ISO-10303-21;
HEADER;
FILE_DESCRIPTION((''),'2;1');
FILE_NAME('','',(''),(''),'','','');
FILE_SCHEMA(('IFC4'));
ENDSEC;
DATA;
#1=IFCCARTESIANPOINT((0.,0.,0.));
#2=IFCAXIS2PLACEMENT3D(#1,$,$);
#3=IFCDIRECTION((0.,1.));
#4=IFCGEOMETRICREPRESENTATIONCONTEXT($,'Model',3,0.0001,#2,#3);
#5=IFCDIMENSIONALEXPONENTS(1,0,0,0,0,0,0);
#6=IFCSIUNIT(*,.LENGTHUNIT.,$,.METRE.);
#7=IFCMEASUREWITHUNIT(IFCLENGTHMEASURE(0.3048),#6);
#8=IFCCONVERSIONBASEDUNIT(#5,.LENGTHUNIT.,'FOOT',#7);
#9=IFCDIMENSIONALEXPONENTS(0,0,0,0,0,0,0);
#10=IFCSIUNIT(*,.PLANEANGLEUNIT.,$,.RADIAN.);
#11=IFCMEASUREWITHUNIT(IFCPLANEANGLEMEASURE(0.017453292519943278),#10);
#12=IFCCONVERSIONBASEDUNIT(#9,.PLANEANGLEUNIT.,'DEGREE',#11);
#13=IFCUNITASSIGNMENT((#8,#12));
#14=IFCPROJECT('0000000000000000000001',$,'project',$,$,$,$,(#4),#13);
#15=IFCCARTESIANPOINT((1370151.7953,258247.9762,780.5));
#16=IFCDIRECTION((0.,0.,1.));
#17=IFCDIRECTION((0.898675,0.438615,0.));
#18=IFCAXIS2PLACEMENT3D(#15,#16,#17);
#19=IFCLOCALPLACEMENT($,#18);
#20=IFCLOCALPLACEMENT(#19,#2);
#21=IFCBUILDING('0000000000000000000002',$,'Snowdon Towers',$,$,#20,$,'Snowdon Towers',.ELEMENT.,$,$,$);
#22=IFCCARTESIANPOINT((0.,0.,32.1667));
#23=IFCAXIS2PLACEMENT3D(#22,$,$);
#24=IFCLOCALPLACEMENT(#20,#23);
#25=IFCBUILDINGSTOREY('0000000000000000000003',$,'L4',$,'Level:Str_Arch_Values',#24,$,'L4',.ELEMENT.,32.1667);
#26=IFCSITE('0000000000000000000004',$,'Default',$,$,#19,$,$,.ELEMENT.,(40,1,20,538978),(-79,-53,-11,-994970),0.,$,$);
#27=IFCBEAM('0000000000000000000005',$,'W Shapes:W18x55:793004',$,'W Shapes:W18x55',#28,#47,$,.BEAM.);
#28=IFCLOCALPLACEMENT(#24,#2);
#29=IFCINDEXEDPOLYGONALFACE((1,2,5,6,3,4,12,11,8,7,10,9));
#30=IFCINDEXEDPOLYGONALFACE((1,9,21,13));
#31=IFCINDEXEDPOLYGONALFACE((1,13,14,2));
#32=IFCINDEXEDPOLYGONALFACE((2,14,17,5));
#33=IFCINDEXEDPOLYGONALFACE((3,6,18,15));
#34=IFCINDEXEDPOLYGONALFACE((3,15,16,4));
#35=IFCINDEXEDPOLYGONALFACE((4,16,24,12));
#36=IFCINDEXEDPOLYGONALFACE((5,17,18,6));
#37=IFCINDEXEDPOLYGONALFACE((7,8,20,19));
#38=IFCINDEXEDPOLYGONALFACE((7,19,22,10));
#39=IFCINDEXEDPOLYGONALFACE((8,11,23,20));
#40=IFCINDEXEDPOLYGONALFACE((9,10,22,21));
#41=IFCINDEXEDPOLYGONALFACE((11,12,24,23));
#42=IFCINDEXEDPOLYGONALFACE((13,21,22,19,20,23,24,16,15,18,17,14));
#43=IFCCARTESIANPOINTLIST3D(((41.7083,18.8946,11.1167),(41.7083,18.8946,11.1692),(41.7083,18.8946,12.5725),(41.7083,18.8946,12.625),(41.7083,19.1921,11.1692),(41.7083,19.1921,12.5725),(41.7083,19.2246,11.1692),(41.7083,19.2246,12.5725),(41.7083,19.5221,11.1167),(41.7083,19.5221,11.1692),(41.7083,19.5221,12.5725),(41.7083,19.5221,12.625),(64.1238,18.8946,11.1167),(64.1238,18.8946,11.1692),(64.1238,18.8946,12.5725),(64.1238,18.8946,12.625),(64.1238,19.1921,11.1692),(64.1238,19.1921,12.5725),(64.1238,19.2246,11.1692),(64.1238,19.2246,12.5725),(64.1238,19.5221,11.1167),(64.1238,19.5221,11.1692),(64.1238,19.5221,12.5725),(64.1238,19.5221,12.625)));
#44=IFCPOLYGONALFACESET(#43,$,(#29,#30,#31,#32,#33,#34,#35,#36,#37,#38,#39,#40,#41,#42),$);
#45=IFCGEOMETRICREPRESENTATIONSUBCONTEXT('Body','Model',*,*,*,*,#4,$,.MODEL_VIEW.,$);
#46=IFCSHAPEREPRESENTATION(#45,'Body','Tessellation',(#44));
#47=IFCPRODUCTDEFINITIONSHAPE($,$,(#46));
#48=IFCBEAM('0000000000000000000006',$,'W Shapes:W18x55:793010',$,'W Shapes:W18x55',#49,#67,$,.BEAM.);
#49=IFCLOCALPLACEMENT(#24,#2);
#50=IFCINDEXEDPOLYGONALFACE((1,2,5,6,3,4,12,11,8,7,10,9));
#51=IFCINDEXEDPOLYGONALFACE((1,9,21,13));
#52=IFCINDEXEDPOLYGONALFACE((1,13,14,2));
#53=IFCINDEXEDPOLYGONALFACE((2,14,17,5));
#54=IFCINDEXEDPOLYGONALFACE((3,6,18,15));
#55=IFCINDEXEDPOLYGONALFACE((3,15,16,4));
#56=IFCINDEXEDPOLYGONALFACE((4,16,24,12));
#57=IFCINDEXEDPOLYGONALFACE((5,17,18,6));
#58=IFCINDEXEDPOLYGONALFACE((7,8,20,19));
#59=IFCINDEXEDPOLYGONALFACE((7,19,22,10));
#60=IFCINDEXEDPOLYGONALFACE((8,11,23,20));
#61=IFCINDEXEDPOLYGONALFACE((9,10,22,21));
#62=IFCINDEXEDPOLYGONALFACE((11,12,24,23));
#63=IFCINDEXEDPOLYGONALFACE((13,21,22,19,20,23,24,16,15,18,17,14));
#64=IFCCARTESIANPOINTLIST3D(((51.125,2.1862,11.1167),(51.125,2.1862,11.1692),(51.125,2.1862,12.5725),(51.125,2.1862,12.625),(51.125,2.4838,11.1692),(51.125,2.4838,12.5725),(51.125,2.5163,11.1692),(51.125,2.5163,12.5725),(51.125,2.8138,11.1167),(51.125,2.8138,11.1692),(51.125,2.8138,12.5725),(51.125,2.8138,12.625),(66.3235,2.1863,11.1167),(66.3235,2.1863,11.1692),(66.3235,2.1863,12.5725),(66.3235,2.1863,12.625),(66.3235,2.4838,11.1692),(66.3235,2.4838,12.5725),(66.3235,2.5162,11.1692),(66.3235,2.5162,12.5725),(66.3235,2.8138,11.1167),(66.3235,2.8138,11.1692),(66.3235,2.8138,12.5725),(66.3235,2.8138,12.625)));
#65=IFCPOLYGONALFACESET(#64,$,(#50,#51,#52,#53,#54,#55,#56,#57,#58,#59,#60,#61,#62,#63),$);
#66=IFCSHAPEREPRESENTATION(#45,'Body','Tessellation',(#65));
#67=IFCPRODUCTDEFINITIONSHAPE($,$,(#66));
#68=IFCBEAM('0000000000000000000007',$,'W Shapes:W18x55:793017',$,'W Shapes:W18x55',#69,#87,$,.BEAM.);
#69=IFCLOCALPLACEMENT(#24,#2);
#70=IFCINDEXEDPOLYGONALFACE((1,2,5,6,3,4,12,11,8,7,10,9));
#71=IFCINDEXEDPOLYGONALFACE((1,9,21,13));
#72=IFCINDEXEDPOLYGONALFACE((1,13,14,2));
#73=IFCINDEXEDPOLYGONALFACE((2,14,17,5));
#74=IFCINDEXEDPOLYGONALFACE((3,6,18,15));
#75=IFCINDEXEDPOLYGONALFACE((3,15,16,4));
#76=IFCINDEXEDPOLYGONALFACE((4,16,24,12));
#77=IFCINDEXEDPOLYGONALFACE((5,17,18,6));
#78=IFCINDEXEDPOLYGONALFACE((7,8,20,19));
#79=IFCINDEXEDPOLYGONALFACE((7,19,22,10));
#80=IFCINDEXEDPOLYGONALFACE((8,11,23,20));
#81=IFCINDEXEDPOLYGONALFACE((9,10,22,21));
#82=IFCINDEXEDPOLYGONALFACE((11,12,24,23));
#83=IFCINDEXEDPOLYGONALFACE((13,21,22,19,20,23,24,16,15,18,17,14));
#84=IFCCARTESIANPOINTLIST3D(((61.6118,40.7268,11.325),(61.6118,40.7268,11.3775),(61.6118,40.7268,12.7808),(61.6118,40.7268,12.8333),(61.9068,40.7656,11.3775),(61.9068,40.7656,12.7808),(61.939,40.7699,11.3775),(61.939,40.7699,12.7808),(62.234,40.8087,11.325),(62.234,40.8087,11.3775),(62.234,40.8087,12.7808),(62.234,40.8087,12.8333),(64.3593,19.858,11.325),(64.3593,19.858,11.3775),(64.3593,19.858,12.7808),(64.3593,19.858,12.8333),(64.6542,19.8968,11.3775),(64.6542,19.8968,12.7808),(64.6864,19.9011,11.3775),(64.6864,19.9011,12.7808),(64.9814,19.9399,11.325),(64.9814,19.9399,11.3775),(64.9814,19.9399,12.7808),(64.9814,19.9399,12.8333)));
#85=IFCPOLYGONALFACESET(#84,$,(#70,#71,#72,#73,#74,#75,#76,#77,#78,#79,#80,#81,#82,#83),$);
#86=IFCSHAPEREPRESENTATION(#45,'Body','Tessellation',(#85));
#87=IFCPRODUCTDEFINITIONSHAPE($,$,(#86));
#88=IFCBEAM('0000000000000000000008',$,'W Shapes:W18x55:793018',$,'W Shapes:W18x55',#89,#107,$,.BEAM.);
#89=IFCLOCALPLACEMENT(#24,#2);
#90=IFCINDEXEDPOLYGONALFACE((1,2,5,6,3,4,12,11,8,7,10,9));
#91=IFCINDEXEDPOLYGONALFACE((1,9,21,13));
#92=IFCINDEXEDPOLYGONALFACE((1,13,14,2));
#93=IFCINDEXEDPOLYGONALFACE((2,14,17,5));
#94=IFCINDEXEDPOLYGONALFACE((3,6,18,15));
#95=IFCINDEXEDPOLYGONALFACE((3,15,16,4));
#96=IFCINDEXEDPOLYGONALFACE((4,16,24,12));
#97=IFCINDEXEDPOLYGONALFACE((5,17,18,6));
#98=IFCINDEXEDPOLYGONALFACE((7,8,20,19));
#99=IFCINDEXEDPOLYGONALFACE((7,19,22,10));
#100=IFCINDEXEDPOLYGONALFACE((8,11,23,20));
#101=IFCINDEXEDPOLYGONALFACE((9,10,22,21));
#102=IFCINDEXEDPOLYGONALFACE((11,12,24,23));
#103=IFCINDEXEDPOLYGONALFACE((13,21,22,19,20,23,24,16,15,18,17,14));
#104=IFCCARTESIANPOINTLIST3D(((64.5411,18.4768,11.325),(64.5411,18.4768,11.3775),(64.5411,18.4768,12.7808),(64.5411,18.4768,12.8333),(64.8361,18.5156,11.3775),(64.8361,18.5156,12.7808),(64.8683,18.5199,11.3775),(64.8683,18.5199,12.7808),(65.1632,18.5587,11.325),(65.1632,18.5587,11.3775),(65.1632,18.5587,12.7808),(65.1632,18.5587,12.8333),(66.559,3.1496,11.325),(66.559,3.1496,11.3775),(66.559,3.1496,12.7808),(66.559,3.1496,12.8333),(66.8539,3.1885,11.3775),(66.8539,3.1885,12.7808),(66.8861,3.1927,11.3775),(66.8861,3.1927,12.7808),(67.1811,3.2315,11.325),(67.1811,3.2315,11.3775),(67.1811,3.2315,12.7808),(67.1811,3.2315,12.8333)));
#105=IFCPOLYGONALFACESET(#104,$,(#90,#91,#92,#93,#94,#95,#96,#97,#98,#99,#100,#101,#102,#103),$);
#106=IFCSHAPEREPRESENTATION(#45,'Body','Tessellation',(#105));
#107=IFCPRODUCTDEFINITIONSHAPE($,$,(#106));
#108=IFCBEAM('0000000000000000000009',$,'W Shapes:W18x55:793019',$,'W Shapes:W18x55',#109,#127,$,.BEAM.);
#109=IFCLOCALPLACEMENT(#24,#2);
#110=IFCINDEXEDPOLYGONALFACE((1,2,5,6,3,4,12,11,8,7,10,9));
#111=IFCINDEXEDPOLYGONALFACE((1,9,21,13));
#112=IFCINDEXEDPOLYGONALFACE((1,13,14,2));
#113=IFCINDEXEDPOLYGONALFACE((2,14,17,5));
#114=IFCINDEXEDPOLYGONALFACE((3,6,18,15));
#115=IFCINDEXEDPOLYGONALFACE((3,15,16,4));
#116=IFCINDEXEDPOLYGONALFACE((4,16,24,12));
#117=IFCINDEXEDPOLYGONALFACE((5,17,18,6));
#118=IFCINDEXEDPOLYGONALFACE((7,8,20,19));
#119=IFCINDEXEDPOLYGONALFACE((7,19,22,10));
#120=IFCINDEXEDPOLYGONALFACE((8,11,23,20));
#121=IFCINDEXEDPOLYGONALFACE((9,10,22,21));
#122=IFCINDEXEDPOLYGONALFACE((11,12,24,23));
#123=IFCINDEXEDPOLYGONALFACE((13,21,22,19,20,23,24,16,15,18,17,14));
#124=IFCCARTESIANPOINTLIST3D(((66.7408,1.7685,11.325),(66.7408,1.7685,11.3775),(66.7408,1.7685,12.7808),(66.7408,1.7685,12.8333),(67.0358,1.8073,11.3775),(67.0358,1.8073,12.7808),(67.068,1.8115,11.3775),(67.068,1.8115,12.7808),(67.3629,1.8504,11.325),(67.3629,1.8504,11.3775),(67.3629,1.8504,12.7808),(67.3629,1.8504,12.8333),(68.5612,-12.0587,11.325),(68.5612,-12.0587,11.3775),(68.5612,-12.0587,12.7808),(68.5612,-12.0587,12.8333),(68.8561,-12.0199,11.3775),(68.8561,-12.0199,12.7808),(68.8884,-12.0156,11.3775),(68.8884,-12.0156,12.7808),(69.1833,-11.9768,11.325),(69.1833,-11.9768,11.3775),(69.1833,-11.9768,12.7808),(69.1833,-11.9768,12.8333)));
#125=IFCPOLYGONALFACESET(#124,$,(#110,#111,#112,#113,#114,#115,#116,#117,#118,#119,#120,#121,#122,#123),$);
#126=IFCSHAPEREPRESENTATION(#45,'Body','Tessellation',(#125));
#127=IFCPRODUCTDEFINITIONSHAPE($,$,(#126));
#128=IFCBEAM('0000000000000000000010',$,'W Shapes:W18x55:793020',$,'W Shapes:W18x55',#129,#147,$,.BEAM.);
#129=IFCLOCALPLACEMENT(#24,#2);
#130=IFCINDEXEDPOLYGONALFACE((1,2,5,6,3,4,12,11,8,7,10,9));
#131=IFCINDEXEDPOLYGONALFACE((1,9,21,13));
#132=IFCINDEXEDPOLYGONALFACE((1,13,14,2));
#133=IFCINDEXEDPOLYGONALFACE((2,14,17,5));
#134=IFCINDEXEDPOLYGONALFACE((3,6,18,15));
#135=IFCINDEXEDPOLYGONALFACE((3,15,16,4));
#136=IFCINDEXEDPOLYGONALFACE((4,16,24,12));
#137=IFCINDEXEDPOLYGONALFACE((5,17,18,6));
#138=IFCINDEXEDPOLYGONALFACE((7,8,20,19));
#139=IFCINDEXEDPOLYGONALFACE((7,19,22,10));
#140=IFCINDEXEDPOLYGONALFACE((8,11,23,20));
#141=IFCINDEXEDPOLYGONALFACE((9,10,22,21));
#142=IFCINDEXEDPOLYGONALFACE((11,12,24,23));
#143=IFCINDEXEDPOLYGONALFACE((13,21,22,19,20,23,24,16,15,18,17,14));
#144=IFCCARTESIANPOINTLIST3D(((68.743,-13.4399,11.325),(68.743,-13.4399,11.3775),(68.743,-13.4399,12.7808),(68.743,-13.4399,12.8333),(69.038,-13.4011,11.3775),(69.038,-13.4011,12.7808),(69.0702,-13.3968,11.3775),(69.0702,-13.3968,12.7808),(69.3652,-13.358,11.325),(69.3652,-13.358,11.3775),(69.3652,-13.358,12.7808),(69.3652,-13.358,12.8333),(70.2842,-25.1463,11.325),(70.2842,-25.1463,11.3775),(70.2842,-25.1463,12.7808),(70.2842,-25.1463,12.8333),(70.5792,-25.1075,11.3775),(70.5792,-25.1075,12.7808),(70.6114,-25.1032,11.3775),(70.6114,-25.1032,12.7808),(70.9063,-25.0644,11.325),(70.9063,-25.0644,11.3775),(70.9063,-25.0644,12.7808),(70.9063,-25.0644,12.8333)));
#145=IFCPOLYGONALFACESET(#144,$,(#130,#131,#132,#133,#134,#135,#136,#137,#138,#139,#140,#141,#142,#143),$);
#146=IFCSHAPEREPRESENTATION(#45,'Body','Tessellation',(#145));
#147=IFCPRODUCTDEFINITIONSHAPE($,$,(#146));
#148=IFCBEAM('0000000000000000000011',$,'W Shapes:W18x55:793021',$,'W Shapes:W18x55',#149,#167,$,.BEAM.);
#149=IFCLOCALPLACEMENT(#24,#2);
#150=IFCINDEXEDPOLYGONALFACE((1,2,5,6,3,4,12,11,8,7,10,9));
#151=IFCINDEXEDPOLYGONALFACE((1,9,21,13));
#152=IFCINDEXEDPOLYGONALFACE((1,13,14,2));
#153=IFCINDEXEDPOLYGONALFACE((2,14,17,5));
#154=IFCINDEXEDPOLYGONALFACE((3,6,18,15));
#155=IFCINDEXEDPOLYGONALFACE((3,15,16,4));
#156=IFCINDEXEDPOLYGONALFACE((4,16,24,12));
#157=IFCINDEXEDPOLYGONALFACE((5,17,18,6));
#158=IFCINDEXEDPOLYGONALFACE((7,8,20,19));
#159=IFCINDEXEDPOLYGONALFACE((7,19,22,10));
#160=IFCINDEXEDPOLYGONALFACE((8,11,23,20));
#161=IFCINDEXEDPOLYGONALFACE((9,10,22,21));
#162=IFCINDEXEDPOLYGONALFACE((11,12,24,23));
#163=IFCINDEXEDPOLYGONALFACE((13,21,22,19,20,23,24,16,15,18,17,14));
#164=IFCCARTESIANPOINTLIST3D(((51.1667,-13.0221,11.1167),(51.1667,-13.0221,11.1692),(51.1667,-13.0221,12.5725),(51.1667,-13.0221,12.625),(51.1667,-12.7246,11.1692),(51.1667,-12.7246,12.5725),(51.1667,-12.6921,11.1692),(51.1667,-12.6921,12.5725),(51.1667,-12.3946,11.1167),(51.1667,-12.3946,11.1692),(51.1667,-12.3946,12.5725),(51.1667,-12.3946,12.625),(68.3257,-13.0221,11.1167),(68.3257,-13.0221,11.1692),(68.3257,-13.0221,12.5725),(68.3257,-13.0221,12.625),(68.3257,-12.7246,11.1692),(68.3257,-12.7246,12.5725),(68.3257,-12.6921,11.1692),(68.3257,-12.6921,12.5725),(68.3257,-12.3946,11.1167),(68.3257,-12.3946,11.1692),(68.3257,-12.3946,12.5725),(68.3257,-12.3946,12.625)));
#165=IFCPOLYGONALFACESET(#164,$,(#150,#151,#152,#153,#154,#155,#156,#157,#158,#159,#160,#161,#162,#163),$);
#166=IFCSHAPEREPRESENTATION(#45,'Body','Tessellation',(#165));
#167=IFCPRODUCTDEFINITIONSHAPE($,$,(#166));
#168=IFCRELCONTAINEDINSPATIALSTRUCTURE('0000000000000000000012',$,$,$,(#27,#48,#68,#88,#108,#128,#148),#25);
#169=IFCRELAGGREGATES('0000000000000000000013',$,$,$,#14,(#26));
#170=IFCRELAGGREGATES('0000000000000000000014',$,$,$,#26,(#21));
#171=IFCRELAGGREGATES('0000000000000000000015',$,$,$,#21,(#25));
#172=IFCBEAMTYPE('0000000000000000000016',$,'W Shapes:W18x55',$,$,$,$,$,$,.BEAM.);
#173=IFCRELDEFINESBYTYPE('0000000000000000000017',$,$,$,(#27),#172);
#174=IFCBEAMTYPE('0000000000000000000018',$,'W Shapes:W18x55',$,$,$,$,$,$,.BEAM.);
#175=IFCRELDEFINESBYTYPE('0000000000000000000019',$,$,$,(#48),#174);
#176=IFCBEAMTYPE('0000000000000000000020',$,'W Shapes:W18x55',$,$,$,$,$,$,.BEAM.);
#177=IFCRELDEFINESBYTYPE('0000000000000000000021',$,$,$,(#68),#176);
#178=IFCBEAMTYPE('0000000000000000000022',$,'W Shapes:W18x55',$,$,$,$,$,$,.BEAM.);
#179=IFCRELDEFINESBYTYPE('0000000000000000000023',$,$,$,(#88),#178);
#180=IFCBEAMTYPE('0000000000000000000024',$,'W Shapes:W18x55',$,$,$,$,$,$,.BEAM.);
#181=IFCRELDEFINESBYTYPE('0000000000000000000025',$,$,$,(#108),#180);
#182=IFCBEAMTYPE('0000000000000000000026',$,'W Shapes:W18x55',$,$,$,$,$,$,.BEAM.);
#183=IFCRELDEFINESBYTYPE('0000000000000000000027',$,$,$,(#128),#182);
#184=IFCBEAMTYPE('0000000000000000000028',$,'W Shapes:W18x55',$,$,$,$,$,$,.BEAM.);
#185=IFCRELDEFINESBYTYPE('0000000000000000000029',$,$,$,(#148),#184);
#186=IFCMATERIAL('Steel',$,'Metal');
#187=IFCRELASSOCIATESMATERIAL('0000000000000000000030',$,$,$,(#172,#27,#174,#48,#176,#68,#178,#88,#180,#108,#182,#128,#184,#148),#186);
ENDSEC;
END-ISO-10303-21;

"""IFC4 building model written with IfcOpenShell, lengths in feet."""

from ifc_helpers import new_model, entity, si_unit, converted_unit, direction, frame, origin, place, context, subcontext, project, spatial, indexed_curve, outline, extrude, source, transform, mapped, material, type_object, type_shapes, element, save


model = new_model("IFC4")

# Units and contexts
model_context = context("Model", 3, precision=0.0001, world=origin(), true_north=direction((0.0, 1.0)))
body_context = subcontext(model_context, "Body", "Model", "MODEL_VIEW")
ifc_project = project(units=[converted_unit("LENGTHUNIT", "FOOT", entity("IfcLengthMeasure", 0.3048), si_unit("LENGTHUNIT", "METRE"), dimensions=[1, 0, 0, 0, 0, 0, 0]), converted_unit("PLANEANGLEUNIT", "DEGREE", entity("IfcPlaneAngleMeasure", 0.017453292519943278), si_unit("PLANEANGLEUNIT", "RADIAN"), dimensions=[0, 0, 0, 0, 0, 0, 0])], contexts=[model_context])

# Site, building, storey
site_placement = place(None, frame((1370151.7953, 258247.9762, 780.5), z_axis=(0.0, 0.0, 1.0), x_axis=(0.898675, 0.438615, 0.0)))
site = spatial("IfcSite", under=ifc_project, at=site_placement, Name="Default", CompositionType="ELEMENT", RefLatitude=(40, 1, 20, 538978), RefLongitude=(-79, -53, -11, -994970), RefElevation=0.0)
building_placement = place(site_placement, origin())
building = spatial("IfcBuilding", under=site, at=building_placement, Name="Snowdon Towers", LongName="Snowdon Towers", CompositionType="ELEMENT")
storey_placement = place(building_placement, frame((0.0, 0.0, 32.1667)))
storey = spatial("IfcBuildingStorey", under=building, at=storey_placement, Name="L4", ObjectType="Level:Str_Arch_Values", LongName="L4", CompositionType="ELEMENT", Elevation=32.1667)

# Shared definitions
ifc_material = material(Name="Steel", Category="Metal")

# Beams
beam_type_1 = type_object("IfcBeamType", Name="W Shapes:W18x55", PredefinedType="BEAM", material=ifc_material)
shared_shape_1 = source(origin(), body_context, "Body", "SweptSolid", [
    extrude(outline(indexed_curve([(-0.3138, -0.7017), (-0.3138, -0.7542), (0.3138, -0.7542), (0.3138, -0.7017), (0.0162, -0.7017), (0.0162, 0.7017), (0.3138, 0.7017), (0.3138, 0.7542), (-0.3137, 0.7542), (-0.3137, 0.7017), (-0.0163, 0.7017), (-0.0163, -0.7017), (-0.3138, -0.7017)], self_intersect=False)), frame((-11.5915, 0.0, 0.0), z_axis=(-1.0, 0.0, 0.0), x_axis=(0.0, -1.0, 0.0)), (0.0, 0.0, -1.0), 22.4154),
])
type_shapes(beam_type_1, [shared_shape_1])
beam_1_placement = place(storey_placement, frame((53.2998, 19.2083, 11.8708)))
element("IfcBeam", 1, at=beam_1_placement, inside=storey, type_object=beam_type_1, material=ifc_material, Name="W Shapes:W18x55:793004", ObjectType="W Shapes:W18x55", PredefinedType="BEAM", context=body_context, shape_type="MappedRepresentation", body=[
    mapped(shared_shape_1, transform((0.0, 0.0, 0.0), scale=1.0)),
])
beam_type_2 = type_object("IfcBeamType", Name="W Shapes:W18x55", PredefinedType="BEAM", material=ifc_material)
shared_shape_2 = source(origin(), body_context, "Body", "SweptSolid", [
    extrude(outline(indexed_curve([(-0.3138, -0.7017), (-0.3138, -0.7542), (0.3138, -0.7542), (0.3138, -0.7017), (0.0162, -0.7017), (0.0162, 0.7017), (0.3138, 0.7017), (0.3138, 0.7542), (-0.3137, 0.7542), (-0.3137, 0.7017), (-0.0163, 0.7017), (-0.0163, -0.7017), (-0.3138, -0.7017)], self_intersect=False)), frame((-8.2122, 0.0, 0.0), z_axis=(-1.0, 0.0, 0.0), x_axis=(0.0, -1.0, 0.0)), (0.0, 0.0, -1.0), 15.1985),
])
type_shapes(beam_type_2, [shared_shape_2])
beam_2_placement = place(storey_placement, frame((59.3372, 2.5, 11.8708)))
element("IfcBeam", 2, at=beam_2_placement, inside=storey, type_object=beam_type_2, material=ifc_material, Name="W Shapes:W18x55:793010", ObjectType="W Shapes:W18x55", PredefinedType="BEAM", context=body_context, shape_type="MappedRepresentation", body=[
    mapped(shared_shape_2, transform((0.0, 0.0, 0.0), scale=1.0)),
])
beam_type_3 = type_object("IfcBeamType", Name="W Shapes:W18x55", PredefinedType="BEAM", material=ifc_material)
shared_shape_3 = source(origin(), body_context, "Body", "SweptSolid", [
    extrude(outline(indexed_curve([(-0.3138, -0.7017), (-0.3138, -0.7542), (0.3138, -0.7542), (0.3138, -0.7017), (0.0162, -0.7017), (0.0162, 0.7017), (0.3138, 0.7017), (0.3138, 0.7542), (-0.3137, 0.7542), (-0.3137, 0.7017), (-0.0163, 0.7017), (-0.0163, -0.7017), (-0.3138, -0.7017)], self_intersect=False)), frame((-10.5172, 0.0, 0.0), z_axis=(-1.0, 0.0, 0.0), x_axis=(0.0, -1.0, 0.0)), (0.0, 0.0, -1.0), 21.0489),
])
type_shapes(beam_type_3, [shared_shape_3])
beam_3_placement = place(storey_placement, frame((63.2957, 30.3405, 12.0792), z_axis=(0.0, 0.0, 1.0), x_axis=(0.130526, -0.991445, 0.0)))
element("IfcBeam", 3, at=beam_3_placement, inside=storey, type_object=beam_type_3, material=ifc_material, Name="W Shapes:W18x55:793017", ObjectType="W Shapes:W18x55", PredefinedType="BEAM", context=body_context, shape_type="MappedRepresentation", body=[
    mapped(shared_shape_3, transform((0.0, 0.0, 0.0), scale=1.0)),
])
beam_type_4 = type_object("IfcBeamType", Name="W Shapes:W18x55", PredefinedType="BEAM", material=ifc_material)
shared_shape_4 = source(origin(), body_context, "Body", "SweptSolid", [
    extrude(outline(indexed_curve([(-0.3138, -0.7017), (-0.3138, -0.7542), (0.3138, -0.7542), (0.3138, -0.7017), (0.0162, -0.7017), (0.0162, 0.7017), (0.3138, 0.7017), (0.3138, 0.7542), (-0.3137, 0.7542), (-0.3137, 0.7017), (-0.0163, 0.7017), (-0.0163, -0.7017), (-0.3138, -0.7017)], self_intersect=False)), frame((-7.8065, 0.0, 0.0), z_axis=(-1.0, 0.0, 0.0), x_axis=(0.0, -1.0, 0.0)), (0.0, 0.0, -1.0), 15.4594),
])
type_shapes(beam_type_4, [shared_shape_4])
beam_4_placement = place(storey_placement, frame((65.8711, 10.778, 12.0792), z_axis=(0.0, 0.0, 1.0), x_axis=(0.130526, -0.991445, 0.0)))
element("IfcBeam", 4, at=beam_4_placement, inside=storey, type_object=beam_type_4, material=ifc_material, Name="W Shapes:W18x55:793018", ObjectType="W Shapes:W18x55", PredefinedType="BEAM", context=body_context, shape_type="MappedRepresentation", body=[
    mapped(shared_shape_4, transform((0.0, 0.0, 0.0), scale=1.0)),
])
beam_type_5 = type_object("IfcBeamType", Name="W Shapes:W18x55", PredefinedType="BEAM", material=ifc_material)
shared_shape_5 = source(origin(), body_context, "Body", "SweptSolid", [
    extrude(outline(indexed_curve([(-0.3138, -0.7017), (-0.3138, -0.7542), (0.3138, -0.7542), (0.3138, -0.7017), (0.0162, -0.7017), (0.0162, 0.7017), (0.3138, 0.7017), (0.3138, 0.7542), (-0.3137, 0.7542), (-0.3137, 0.7017), (-0.0163, 0.7017), (-0.0163, -0.7017), (-0.3138, -0.7017)], self_intersect=False)), frame((-7.05, 0.0, 0.0), z_axis=(-1.0, 0.0, 0.0), x_axis=(0.0, -1.0, 0.0)), (0.0, 0.0, -1.0), 13.9465),
])
type_shapes(beam_type_5, [shared_shape_5])
beam_5_placement = place(storey_placement, frame((67.9721, -5.1803, 12.0792), z_axis=(0.0, 0.0, 1.0), x_axis=(0.130526, -0.991445, 0.0)))
element("IfcBeam", 5, at=beam_5_placement, inside=storey, type_object=beam_type_5, material=ifc_material, Name="W Shapes:W18x55:793019", ObjectType="W Shapes:W18x55", PredefinedType="BEAM", context=body_context, shape_type="MappedRepresentation", body=[
    mapped(shared_shape_5, transform((0.0, 0.0, 0.0), scale=1.0)),
])
beam_type_6 = type_object("IfcBeamType", Name="W Shapes:W18x55", PredefinedType="BEAM", material=ifc_material)
shared_shape_6 = source(origin(), body_context, "Body", "SweptSolid", [
    extrude(outline(indexed_curve([(-0.3138, -0.7017), (-0.3138, -0.7542), (0.3138, -0.7542), (0.3138, -0.7017), (0.0162, -0.7017), (0.0162, 0.7017), (0.3138, 0.7017), (0.3138, 0.7542), (-0.3137, 0.7542), (-0.3137, 0.7017), (-0.0163, 0.7017), (-0.0163, -0.7017), (-0.3138, -0.7017)], self_intersect=False)), frame((-5.9188, 0.0, 0.0), z_axis=(-1.0, 0.0, 0.0), x_axis=(0.0, -1.0, 0.0)), (0.0, 0.0, -1.0), 11.8075),
])
type_shapes(beam_type_6, [shared_shape_6])
beam_6_placement = place(storey_placement, frame((69.8266, -19.2671, 12.0792), z_axis=(0.0, 0.0, 1.0), x_axis=(0.130526, -0.991445, 0.0)))
element("IfcBeam", 6, at=beam_6_placement, inside=storey, type_object=beam_type_6, material=ifc_material, Name="W Shapes:W18x55:793020", ObjectType="W Shapes:W18x55", PredefinedType="BEAM", context=body_context, shape_type="MappedRepresentation", body=[
    mapped(shared_shape_6, transform((0.0, 0.0, 0.0), scale=1.0)),
])
beam_type_7 = type_object("IfcBeamType", Name="W Shapes:W18x55", PredefinedType="BEAM", material=ifc_material)
shared_shape_7 = source(origin(), body_context, "Body", "SweptSolid", [
    extrude(outline(indexed_curve([(-0.3138, -0.7017), (-0.3138, -0.7542), (0.3138, -0.7542), (0.3138, -0.7017), (0.0162, -0.7017), (0.0162, 0.7017), (0.3138, 0.7017), (0.3138, 0.7542), (-0.3137, 0.7542), (-0.3137, 0.7017), (-0.0163, 0.7017), (-0.0163, -0.7017), (-0.3138, -0.7017)], self_intersect=False)), frame((-8.9216, 0.0, 0.0), z_axis=(-1.0, 0.0, 0.0), x_axis=(0.0, -1.0, 0.0)), (0.0, 0.0, -1.0), 17.159),
])
type_shapes(beam_type_7, [shared_shape_7])
beam_7_placement = place(storey_placement, frame((60.0883, -12.7083, 11.8708)))
element("IfcBeam", 7, at=beam_7_placement, inside=storey, type_object=beam_type_7, material=ifc_material, Name="W Shapes:W18x55:793021", ObjectType="W Shapes:W18x55", PredefinedType="BEAM", context=body_context, shape_type="MappedRepresentation", body=[
    mapped(shared_shape_7, transform((0.0, 0.0, 0.0), scale=1.0)),
])

save(model, "model.ifc")
